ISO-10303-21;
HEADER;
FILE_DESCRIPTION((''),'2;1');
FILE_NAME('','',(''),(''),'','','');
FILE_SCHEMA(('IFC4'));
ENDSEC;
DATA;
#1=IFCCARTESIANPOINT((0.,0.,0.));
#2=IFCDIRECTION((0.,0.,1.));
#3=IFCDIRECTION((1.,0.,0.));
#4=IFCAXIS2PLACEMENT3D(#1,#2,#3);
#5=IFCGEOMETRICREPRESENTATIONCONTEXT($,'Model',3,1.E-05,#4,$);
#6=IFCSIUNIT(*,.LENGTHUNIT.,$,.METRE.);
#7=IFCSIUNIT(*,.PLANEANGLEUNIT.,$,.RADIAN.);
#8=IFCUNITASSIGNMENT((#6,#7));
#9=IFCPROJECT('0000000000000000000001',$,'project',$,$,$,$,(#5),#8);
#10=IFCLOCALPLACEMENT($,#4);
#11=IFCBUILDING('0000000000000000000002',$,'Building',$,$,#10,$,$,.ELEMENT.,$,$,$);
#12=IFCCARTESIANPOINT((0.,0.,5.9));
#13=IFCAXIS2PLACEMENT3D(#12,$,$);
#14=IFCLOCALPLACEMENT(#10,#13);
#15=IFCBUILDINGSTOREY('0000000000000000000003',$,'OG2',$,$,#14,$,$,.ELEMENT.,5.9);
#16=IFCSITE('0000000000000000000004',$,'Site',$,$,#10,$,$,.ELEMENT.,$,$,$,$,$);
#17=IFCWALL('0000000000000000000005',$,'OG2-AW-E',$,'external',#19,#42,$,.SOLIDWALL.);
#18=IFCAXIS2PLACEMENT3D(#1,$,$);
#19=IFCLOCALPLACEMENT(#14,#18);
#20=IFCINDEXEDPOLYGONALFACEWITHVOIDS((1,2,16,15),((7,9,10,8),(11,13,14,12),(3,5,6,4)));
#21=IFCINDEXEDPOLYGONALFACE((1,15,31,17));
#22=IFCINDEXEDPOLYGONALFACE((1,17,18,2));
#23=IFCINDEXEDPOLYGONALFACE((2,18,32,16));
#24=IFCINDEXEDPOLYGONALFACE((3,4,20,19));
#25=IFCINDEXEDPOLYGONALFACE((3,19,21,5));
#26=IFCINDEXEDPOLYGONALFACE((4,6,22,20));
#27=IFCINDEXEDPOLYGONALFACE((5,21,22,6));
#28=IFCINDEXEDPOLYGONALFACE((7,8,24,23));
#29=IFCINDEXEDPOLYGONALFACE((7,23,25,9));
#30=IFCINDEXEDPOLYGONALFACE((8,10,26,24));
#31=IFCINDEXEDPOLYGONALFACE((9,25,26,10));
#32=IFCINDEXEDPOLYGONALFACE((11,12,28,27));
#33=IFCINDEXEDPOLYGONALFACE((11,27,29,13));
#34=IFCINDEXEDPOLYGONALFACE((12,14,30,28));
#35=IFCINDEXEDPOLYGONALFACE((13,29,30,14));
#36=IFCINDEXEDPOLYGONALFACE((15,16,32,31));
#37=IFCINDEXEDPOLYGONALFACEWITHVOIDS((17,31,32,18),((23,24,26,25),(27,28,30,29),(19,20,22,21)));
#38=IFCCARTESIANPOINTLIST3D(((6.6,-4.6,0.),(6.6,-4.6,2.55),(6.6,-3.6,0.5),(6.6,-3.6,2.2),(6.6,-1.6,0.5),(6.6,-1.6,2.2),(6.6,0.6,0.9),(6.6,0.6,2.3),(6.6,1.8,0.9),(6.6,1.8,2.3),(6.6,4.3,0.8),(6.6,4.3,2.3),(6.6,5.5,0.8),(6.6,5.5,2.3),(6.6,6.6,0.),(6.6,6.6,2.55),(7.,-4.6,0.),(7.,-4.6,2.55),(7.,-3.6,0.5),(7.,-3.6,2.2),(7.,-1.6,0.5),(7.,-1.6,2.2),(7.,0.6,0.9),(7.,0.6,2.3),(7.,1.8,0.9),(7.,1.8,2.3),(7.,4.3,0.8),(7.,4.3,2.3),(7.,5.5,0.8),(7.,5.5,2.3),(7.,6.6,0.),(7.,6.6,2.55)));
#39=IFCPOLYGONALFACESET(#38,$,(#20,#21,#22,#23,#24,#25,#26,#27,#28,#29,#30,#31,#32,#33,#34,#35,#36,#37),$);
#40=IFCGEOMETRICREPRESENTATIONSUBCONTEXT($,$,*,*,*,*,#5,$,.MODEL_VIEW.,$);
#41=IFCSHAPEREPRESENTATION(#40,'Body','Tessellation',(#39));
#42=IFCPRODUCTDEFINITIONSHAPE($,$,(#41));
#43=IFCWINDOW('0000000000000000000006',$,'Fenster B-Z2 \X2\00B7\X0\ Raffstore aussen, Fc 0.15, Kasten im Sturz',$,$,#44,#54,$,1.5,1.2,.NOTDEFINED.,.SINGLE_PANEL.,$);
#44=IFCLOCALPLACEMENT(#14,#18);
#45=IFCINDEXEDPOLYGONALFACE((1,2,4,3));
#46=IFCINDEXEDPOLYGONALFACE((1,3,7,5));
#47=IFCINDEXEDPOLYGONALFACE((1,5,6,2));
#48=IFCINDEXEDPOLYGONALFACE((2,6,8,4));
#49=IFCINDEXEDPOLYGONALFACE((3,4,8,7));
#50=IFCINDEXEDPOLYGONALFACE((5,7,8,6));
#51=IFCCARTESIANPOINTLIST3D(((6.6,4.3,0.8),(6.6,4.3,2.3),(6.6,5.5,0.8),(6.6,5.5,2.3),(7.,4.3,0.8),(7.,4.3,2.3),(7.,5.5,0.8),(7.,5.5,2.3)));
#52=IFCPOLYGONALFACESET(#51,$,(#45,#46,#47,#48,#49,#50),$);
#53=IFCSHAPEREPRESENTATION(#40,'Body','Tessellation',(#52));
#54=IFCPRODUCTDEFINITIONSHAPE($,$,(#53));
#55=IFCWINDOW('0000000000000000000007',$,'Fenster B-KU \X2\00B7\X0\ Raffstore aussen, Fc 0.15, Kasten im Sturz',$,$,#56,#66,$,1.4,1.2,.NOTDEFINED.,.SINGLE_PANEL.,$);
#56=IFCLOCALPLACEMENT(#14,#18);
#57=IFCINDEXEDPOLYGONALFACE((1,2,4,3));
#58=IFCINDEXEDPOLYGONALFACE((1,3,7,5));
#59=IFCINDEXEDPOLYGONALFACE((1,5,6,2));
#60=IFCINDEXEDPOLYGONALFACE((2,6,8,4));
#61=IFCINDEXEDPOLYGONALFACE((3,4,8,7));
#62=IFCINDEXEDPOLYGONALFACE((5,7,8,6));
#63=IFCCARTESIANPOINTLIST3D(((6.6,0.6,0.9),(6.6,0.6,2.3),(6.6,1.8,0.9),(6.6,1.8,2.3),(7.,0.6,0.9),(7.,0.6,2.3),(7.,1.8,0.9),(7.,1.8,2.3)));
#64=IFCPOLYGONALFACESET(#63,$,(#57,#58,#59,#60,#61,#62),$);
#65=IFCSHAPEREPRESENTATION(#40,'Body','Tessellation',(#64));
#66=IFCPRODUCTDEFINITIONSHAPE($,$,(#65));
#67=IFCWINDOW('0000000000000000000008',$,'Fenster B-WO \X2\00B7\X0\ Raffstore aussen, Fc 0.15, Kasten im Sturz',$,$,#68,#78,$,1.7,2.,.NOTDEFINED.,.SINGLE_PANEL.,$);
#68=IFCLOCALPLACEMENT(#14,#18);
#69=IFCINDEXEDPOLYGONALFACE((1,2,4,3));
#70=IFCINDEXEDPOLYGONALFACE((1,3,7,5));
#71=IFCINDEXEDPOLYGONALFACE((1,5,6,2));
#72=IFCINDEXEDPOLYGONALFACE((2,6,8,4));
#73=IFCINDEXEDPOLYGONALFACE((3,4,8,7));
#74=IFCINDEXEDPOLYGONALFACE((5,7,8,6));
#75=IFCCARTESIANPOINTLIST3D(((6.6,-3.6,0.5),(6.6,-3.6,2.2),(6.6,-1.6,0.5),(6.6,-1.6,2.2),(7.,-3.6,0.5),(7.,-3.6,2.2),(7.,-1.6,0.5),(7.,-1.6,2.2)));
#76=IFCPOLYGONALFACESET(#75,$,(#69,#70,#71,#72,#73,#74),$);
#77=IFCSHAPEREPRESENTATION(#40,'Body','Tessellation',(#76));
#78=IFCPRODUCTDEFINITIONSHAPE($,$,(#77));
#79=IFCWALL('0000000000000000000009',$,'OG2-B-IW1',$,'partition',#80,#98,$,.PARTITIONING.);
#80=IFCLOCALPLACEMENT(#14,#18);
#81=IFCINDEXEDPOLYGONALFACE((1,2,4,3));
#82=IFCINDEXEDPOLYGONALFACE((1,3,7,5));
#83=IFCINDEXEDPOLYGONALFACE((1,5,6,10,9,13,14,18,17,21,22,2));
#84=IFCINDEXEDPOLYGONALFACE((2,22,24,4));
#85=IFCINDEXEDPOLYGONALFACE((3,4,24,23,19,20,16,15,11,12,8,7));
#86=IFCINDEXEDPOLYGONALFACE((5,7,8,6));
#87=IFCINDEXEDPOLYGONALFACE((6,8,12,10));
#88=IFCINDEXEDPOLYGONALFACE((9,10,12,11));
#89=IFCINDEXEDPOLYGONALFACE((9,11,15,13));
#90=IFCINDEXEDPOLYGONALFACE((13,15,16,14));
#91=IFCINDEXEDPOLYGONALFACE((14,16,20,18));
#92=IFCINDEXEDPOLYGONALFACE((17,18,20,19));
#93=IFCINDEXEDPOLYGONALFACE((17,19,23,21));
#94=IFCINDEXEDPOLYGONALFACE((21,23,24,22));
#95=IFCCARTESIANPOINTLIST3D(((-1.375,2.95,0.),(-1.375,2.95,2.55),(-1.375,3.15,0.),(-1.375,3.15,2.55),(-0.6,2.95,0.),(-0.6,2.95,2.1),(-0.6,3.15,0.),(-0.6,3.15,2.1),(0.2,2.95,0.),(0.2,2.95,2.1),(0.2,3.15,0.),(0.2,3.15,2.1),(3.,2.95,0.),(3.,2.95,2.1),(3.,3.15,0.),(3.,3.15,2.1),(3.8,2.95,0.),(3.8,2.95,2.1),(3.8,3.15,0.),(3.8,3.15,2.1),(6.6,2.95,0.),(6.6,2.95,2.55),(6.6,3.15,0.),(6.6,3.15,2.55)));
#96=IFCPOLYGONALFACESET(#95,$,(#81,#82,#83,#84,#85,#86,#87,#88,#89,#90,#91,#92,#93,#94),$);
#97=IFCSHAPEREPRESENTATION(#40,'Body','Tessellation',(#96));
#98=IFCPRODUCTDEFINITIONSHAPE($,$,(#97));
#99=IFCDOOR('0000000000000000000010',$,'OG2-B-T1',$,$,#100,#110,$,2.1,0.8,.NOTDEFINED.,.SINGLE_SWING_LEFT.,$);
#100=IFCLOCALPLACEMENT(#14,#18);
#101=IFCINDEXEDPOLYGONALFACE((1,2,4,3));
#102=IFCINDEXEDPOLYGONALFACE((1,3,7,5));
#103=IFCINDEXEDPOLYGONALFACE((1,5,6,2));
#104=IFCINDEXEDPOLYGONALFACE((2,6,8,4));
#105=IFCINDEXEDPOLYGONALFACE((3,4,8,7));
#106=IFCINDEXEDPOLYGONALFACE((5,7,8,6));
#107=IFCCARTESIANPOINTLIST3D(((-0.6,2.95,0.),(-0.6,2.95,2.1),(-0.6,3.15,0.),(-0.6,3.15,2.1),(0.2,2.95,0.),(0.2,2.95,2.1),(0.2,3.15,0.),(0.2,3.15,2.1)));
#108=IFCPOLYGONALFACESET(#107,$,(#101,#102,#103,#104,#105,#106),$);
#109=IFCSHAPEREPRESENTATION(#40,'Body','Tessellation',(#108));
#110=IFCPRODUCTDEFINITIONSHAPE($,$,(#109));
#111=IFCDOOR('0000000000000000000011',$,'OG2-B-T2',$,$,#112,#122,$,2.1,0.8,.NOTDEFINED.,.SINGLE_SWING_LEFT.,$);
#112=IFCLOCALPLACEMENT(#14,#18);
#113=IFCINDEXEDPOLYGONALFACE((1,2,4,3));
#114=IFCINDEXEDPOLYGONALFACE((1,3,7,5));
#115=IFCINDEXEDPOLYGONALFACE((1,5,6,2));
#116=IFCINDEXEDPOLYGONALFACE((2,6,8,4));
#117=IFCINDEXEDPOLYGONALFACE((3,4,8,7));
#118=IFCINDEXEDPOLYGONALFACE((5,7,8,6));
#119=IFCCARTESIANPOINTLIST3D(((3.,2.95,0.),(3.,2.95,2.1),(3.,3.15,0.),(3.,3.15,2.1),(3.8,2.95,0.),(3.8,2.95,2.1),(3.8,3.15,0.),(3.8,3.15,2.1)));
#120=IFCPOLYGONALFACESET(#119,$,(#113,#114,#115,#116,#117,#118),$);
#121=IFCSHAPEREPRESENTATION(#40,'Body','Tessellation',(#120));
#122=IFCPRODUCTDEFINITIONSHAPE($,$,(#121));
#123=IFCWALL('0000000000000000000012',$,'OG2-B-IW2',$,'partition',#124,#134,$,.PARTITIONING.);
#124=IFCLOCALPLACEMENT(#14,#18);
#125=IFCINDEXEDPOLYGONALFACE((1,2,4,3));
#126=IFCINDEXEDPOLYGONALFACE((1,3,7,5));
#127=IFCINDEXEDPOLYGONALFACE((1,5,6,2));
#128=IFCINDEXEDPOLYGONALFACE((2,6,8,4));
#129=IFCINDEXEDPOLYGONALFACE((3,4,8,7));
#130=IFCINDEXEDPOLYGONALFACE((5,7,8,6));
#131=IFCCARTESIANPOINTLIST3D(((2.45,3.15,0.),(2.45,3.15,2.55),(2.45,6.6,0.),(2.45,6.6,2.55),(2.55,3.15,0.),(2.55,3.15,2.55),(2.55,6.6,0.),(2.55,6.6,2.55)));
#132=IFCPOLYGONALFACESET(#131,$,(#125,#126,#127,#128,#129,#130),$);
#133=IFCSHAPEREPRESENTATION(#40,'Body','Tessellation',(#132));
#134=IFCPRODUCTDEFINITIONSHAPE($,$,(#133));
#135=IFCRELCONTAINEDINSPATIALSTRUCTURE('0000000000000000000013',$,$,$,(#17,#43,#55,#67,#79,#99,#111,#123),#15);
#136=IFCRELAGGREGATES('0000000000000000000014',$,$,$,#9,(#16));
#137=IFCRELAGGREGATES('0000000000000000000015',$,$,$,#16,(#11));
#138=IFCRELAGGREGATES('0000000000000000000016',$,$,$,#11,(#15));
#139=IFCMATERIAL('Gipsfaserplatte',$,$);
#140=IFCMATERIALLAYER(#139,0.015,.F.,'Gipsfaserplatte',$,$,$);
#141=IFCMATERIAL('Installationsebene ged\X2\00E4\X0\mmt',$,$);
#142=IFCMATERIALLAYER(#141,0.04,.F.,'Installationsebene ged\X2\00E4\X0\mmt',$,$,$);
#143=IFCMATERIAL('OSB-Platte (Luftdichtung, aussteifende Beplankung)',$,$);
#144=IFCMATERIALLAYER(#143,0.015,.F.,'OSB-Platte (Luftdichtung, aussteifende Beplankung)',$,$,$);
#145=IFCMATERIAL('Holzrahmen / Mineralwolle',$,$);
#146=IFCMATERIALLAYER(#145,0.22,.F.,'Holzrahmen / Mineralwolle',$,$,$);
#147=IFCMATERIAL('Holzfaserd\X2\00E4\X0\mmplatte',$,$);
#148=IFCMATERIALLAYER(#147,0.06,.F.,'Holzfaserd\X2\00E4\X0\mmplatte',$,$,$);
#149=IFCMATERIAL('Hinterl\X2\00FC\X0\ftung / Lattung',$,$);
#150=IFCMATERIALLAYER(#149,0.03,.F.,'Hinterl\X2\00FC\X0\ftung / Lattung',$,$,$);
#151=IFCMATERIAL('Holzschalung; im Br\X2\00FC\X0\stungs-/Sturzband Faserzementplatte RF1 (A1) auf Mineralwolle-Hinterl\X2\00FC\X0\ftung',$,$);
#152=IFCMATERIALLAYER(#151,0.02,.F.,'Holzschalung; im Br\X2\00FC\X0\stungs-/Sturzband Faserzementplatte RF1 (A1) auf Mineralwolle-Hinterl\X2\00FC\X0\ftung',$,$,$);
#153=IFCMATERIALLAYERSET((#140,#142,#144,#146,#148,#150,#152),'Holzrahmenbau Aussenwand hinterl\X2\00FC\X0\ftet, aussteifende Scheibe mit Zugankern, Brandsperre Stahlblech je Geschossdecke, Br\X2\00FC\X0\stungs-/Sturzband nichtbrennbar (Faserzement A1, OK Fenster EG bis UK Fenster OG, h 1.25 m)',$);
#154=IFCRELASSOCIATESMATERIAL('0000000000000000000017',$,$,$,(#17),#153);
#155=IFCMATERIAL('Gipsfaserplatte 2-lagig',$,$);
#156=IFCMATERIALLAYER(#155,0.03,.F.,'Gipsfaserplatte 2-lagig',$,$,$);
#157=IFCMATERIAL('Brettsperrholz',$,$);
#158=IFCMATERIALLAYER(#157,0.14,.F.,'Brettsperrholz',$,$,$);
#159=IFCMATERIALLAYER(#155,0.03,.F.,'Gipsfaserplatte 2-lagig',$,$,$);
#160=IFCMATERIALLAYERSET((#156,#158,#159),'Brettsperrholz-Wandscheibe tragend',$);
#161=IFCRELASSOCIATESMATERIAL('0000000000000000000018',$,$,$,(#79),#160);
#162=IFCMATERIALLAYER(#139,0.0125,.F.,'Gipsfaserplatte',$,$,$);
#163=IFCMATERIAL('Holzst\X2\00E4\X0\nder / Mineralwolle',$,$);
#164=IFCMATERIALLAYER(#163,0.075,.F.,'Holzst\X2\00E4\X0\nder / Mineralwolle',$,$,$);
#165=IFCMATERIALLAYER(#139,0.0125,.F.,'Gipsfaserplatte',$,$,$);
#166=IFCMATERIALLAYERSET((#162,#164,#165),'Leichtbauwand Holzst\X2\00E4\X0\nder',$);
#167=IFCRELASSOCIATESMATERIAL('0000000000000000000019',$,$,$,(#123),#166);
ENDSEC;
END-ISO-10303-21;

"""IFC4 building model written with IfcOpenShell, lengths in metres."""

from ifc_helpers import new_model, si_unit, frame, frame_2d, origin, origin_with_axes, place, context, subcontext, project, spatial, rectangle, extrude, material, layer, layer_set, element, fill, save


model = new_model("IFC4")

# Units and contexts
model_context = context("Model", 3, precision=1e-05, world=origin_with_axes())
sub_context = subcontext(model_context, None, None, "MODEL_VIEW")
ifc_project = project(units=[si_unit("LENGTHUNIT", "METRE"), si_unit("PLANEANGLEUNIT", "RADIAN")], contexts=[model_context])

# Site, building, storey
placement = place(None, origin_with_axes())
site = spatial("IfcSite", under=ifc_project, at=placement, Name="Site", CompositionType="ELEMENT")
building = spatial("IfcBuilding", under=site, at=placement, Name="Building", CompositionType="ELEMENT")
storey_placement = place(placement, frame((0.0, 0.0, 5.9)))
storey = spatial("IfcBuildingStorey", under=building, at=storey_placement, Name="OG2", CompositionType="ELEMENT", Elevation=5.9)

# Wall, openings, windows
ifc_material_1 = material(Name="Gipsfaserplatte")
ifc_material_2 = material(Name="Installationsebene gedämmt")
ifc_material_3 = material(Name="OSB-Platte (Luftdichtung, aussteifende Beplankung)")
ifc_material_4 = material(Name="Holzrahmen / Mineralwolle")
ifc_material_5 = material(Name="Holzfaserdämmplatte")
ifc_material_6 = material(Name="Hinterlüftung / Lattung")
ifc_layer_1 = layer(ifc_material_1, 0.015, ventilated=False, Name="Gipsfaserplatte")
ifc_layer_2 = layer(ifc_material_2, 0.04, ventilated=False, Name="Installationsebene gedämmt")
ifc_layer_3 = layer(ifc_material_3, 0.015, ventilated=False, Name="OSB-Platte (Luftdichtung, aussteifende Beplankung)")
ifc_layer_4 = layer(ifc_material_4, 0.22, ventilated=False, Name="Holzrahmen / Mineralwolle")
ifc_layer_5 = layer(ifc_material_5, 0.06, ventilated=False, Name="Holzfaserdämmplatte")
ifc_layer_6 = layer(ifc_material_6, 0.03, ventilated=False, Name="Hinterlüftung / Lattung")
ifc_material_7 = material(Name="Holzschalung; im Brüstungs-/Sturzband Faserzementplatte RF1 (A1) auf Mineralwolle-Hinterlüftung")
ifc_layer_7 = layer(ifc_material_7, 0.02, ventilated=False, Name="Holzschalung; im Brüstungs-/Sturzband Faserzementplatte RF1 (A1) auf Mineralwolle-Hinterlüftung")
ifc_layer_set_1 = layer_set([ifc_layer_1, ifc_layer_2, ifc_layer_3, ifc_layer_4, ifc_layer_5, ifc_layer_6, ifc_layer_7], Name="Holzrahmenbau Aussenwand hinterlüftet, aussteifende Scheibe mit Zugankern, Brandsperre Stahlblech je Geschossdecke, Brüstungs-/Sturzband nichtbrennbar (Faserzement A1, OK Fenster EG bis UK Fenster OG, h 1.25 m)")
wall_1_placement = place(storey_placement, frame((6.8, 6.6, 0.0), z_axis=(0.0, 0.0, 1.0), x_axis=(0.0, -1.0, 0.0)))
wall_1 = element("IfcWall", 1, at=wall_1_placement, inside=storey, material=ifc_layer_set_1, Name="OG2-AW-E", ObjectType="external", PredefinedType="SOLIDWALL", context=sub_context, shape_type="SweptSolid", body=[
    extrude(rectangle(XDim=11.2, YDim=0.4, at=frame_2d((5.6, 0.0))), origin(), (0.0, 0.0, 1.0), 2.55),
])
opening_1_placement = place(wall_1_placement, frame((1.7, 0.25, 0.8), z_axis=(0.0, -1.0, 0.0), x_axis=(1.0, 0.0, 0.0)))
opening_1 = element("IfcOpeningElement", 2, at=opening_1_placement, cuts=wall_1, PredefinedType="OPENING", context=sub_context, shape_type="SweptSolid", body=[
    extrude(rectangle(XDim=1.2, YDim=1.5, at=frame_2d((0.0, 0.75))), origin(), (0.0, 0.0, 1.0), 0.5),
])
opening_2_placement = place(wall_1_placement, frame((5.4, 0.25, 0.9), z_axis=(0.0, -1.0, 0.0), x_axis=(1.0, 0.0, 0.0)))
opening_2 = element("IfcOpeningElement", 3, at=opening_2_placement, cuts=wall_1, PredefinedType="OPENING", context=sub_context, shape_type="SweptSolid", body=[
    extrude(rectangle(XDim=1.2, YDim=1.4, at=frame_2d((0.0, 0.7))), origin(), (0.0, 0.0, 1.0), 0.5),
])
opening_3_placement = place(wall_1_placement, frame((9.2, 0.25, 0.5), z_axis=(0.0, -1.0, 0.0), x_axis=(1.0, 0.0, 0.0)))
opening_3 = element("IfcOpeningElement", 4, at=opening_3_placement, cuts=wall_1, PredefinedType="OPENING", context=sub_context, shape_type="SweptSolid", body=[
    extrude(rectangle(XDim=2.0, YDim=1.7, at=frame_2d((0.0, 0.85))), origin(), (0.0, 0.0, 1.0), 0.5),
])
window_1_placement = place(wall_1_placement, frame((1.7, 0.2, 0.8), z_axis=(0.0, -1.0, 0.0), x_axis=(1.0, 0.0, 0.0)))
window_1 = element("IfcWindow", 5, at=window_1_placement, inside=storey, Name="Fenster B-Z2 · Raffstore aussen, Fc 0.15, Kasten im Sturz", OverallHeight=1.5, OverallWidth=1.2, PartitioningType="SINGLE_PANEL", PredefinedType="NOTDEFINED", context=sub_context, shape_type="SweptSolid", body=[
    extrude(rectangle(XDim=1.2, YDim=1.5, at=frame_2d((0.0, 0.75))), origin(), (0.0, 0.0, 1.0), 0.4),
])
fill(opening_1, window_1)
window_2_placement = place(wall_1_placement, frame((5.4, 0.2, 0.9), z_axis=(0.0, -1.0, 0.0), x_axis=(1.0, 0.0, 0.0)))
window_2 = element("IfcWindow", 6, at=window_2_placement, inside=storey, Name="Fenster B-KU · Raffstore aussen, Fc 0.15, Kasten im Sturz", OverallHeight=1.4, OverallWidth=1.2, PartitioningType="SINGLE_PANEL", PredefinedType="NOTDEFINED", context=sub_context, shape_type="SweptSolid", body=[
    extrude(rectangle(XDim=1.2, YDim=1.4, at=frame_2d((0.0, 0.7))), origin(), (0.0, 0.0, 1.0), 0.4),
])
fill(opening_2, window_2)
window_3_placement = place(wall_1_placement, frame((9.2, 0.2, 0.5), z_axis=(0.0, -1.0, 0.0), x_axis=(1.0, 0.0, 0.0)))
window_3 = element("IfcWindow", 7, at=window_3_placement, inside=storey, Name="Fenster B-WO · Raffstore aussen, Fc 0.15, Kasten im Sturz", OverallHeight=1.7, OverallWidth=2.0, PartitioningType="SINGLE_PANEL", PredefinedType="NOTDEFINED", context=sub_context, shape_type="SweptSolid", body=[
    extrude(rectangle(XDim=2.0, YDim=1.7, at=frame_2d((0.0, 0.85))), origin(), (0.0, 0.0, 1.0), 0.4),
])
fill(opening_3, window_3)

# Wall, openings, doors
ifc_material_8 = material(Name="Gipsfaserplatte 2-lagig")
ifc_layer_8 = layer(ifc_material_8, 0.03, ventilated=False, Name="Gipsfaserplatte 2-lagig")
ifc_material_9 = material(Name="Brettsperrholz")
ifc_layer_9 = layer(ifc_material_9, 0.14, ventilated=False, Name="Brettsperrholz")
ifc_layer_10 = layer(ifc_material_8, 0.03, ventilated=False, Name="Gipsfaserplatte 2-lagig")
ifc_layer_set_2 = layer_set([ifc_layer_8, ifc_layer_9, ifc_layer_10], Name="Brettsperrholz-Wandscheibe tragend")
wall_2_placement = place(storey_placement, frame((-1.375, 3.05, 0.0), z_axis=(0.0, 0.0, 1.0), x_axis=(1.0, 0.0, 0.0)))
wall_2 = element("IfcWall", 8, at=wall_2_placement, inside=storey, material=ifc_layer_set_2, Name="OG2-B-IW1", ObjectType="partition", PredefinedType="PARTITIONING", context=sub_context, shape_type="SweptSolid", body=[
    extrude(rectangle(XDim=7.975, YDim=0.2, at=frame_2d((3.9875, 0.0))), origin(), (0.0, 0.0, 1.0), 2.55),
])
opening_4_placement = place(wall_2_placement, frame((1.175, 0.15, 0.0), z_axis=(0.0, -1.0, 0.0), x_axis=(1.0, 0.0, 0.0)))
opening_4 = element("IfcOpeningElement", 9, at=opening_4_placement, cuts=wall_2, PredefinedType="OPENING", context=sub_context, shape_type="SweptSolid", body=[
    extrude(rectangle(XDim=0.8, YDim=2.1, at=frame_2d((0.0, 1.05))), origin(), (0.0, 0.0, 1.0), 0.3),
])
opening_5_placement = place(wall_2_placement, frame((4.775, 0.15, 0.0), z_axis=(0.0, -1.0, 0.0), x_axis=(1.0, 0.0, 0.0)))
opening_5 = element("IfcOpeningElement", 10, at=opening_5_placement, cuts=wall_2, PredefinedType="OPENING", context=sub_context, shape_type="SweptSolid", body=[
    extrude(rectangle(XDim=0.8, YDim=2.1, at=frame_2d((0.0, 1.05))), origin(), (0.0, 0.0, 1.0), 0.3),
])
door_1_placement = place(wall_2_placement, frame((1.175, 0.1, 0.0), z_axis=(0.0, -1.0, 0.0), x_axis=(1.0, 0.0, 0.0)))
door_1 = element("IfcDoor", 11, at=door_1_placement, inside=storey, Name="OG2-B-T1", OperationType="SINGLE_SWING_LEFT", OverallHeight=2.1, OverallWidth=0.8, PredefinedType="NOTDEFINED", context=sub_context, shape_type="SweptSolid", body=[
    extrude(rectangle(XDim=0.8, YDim=2.1, at=frame_2d((0.0, 1.05))), origin(), (0.0, 0.0, 1.0), 0.2),
])
fill(opening_4, door_1)
door_2_placement = place(wall_2_placement, frame((4.775, 0.1, 0.0), z_axis=(0.0, -1.0, 0.0), x_axis=(1.0, 0.0, 0.0)))
door_2 = element("IfcDoor", 12, at=door_2_placement, inside=storey, Name="OG2-B-T2", OperationType="SINGLE_SWING_LEFT", OverallHeight=2.1, OverallWidth=0.8, PredefinedType="NOTDEFINED", context=sub_context, shape_type="SweptSolid", body=[
    extrude(rectangle(XDim=0.8, YDim=2.1, at=frame_2d((0.0, 1.05))), origin(), (0.0, 0.0, 1.0), 0.2),
])
fill(opening_5, door_2)

# Wall
ifc_layer_11 = layer(ifc_material_1, 0.0125, ventilated=False, Name="Gipsfaserplatte")
ifc_material_10 = material(Name="Holzständer / Mineralwolle")
ifc_layer_12 = layer(ifc_material_10, 0.075, ventilated=False, Name="Holzständer / Mineralwolle")
ifc_layer_13 = layer(ifc_material_1, 0.0125, ventilated=False, Name="Gipsfaserplatte")
ifc_layer_set_3 = layer_set([ifc_layer_11, ifc_layer_12, ifc_layer_13], Name="Leichtbauwand Holzständer")
wall_3_placement = place(storey_placement, frame((2.5, 3.15, 0.0), z_axis=(0.0, 0.0, 1.0), x_axis=(0.0, 1.0, 0.0)))
element("IfcWall", 13, at=wall_3_placement, inside=storey, material=ifc_layer_set_3, Name="OG2-B-IW2", ObjectType="partition", PredefinedType="PARTITIONING", context=sub_context, shape_type="SweptSolid", body=[
    extrude(rectangle(XDim=3.45, YDim=0.1, at=frame_2d((1.725, 0.0))), origin(), (0.0, 0.0, 1.0), 2.55),
])

save(model, "model.ifc")
